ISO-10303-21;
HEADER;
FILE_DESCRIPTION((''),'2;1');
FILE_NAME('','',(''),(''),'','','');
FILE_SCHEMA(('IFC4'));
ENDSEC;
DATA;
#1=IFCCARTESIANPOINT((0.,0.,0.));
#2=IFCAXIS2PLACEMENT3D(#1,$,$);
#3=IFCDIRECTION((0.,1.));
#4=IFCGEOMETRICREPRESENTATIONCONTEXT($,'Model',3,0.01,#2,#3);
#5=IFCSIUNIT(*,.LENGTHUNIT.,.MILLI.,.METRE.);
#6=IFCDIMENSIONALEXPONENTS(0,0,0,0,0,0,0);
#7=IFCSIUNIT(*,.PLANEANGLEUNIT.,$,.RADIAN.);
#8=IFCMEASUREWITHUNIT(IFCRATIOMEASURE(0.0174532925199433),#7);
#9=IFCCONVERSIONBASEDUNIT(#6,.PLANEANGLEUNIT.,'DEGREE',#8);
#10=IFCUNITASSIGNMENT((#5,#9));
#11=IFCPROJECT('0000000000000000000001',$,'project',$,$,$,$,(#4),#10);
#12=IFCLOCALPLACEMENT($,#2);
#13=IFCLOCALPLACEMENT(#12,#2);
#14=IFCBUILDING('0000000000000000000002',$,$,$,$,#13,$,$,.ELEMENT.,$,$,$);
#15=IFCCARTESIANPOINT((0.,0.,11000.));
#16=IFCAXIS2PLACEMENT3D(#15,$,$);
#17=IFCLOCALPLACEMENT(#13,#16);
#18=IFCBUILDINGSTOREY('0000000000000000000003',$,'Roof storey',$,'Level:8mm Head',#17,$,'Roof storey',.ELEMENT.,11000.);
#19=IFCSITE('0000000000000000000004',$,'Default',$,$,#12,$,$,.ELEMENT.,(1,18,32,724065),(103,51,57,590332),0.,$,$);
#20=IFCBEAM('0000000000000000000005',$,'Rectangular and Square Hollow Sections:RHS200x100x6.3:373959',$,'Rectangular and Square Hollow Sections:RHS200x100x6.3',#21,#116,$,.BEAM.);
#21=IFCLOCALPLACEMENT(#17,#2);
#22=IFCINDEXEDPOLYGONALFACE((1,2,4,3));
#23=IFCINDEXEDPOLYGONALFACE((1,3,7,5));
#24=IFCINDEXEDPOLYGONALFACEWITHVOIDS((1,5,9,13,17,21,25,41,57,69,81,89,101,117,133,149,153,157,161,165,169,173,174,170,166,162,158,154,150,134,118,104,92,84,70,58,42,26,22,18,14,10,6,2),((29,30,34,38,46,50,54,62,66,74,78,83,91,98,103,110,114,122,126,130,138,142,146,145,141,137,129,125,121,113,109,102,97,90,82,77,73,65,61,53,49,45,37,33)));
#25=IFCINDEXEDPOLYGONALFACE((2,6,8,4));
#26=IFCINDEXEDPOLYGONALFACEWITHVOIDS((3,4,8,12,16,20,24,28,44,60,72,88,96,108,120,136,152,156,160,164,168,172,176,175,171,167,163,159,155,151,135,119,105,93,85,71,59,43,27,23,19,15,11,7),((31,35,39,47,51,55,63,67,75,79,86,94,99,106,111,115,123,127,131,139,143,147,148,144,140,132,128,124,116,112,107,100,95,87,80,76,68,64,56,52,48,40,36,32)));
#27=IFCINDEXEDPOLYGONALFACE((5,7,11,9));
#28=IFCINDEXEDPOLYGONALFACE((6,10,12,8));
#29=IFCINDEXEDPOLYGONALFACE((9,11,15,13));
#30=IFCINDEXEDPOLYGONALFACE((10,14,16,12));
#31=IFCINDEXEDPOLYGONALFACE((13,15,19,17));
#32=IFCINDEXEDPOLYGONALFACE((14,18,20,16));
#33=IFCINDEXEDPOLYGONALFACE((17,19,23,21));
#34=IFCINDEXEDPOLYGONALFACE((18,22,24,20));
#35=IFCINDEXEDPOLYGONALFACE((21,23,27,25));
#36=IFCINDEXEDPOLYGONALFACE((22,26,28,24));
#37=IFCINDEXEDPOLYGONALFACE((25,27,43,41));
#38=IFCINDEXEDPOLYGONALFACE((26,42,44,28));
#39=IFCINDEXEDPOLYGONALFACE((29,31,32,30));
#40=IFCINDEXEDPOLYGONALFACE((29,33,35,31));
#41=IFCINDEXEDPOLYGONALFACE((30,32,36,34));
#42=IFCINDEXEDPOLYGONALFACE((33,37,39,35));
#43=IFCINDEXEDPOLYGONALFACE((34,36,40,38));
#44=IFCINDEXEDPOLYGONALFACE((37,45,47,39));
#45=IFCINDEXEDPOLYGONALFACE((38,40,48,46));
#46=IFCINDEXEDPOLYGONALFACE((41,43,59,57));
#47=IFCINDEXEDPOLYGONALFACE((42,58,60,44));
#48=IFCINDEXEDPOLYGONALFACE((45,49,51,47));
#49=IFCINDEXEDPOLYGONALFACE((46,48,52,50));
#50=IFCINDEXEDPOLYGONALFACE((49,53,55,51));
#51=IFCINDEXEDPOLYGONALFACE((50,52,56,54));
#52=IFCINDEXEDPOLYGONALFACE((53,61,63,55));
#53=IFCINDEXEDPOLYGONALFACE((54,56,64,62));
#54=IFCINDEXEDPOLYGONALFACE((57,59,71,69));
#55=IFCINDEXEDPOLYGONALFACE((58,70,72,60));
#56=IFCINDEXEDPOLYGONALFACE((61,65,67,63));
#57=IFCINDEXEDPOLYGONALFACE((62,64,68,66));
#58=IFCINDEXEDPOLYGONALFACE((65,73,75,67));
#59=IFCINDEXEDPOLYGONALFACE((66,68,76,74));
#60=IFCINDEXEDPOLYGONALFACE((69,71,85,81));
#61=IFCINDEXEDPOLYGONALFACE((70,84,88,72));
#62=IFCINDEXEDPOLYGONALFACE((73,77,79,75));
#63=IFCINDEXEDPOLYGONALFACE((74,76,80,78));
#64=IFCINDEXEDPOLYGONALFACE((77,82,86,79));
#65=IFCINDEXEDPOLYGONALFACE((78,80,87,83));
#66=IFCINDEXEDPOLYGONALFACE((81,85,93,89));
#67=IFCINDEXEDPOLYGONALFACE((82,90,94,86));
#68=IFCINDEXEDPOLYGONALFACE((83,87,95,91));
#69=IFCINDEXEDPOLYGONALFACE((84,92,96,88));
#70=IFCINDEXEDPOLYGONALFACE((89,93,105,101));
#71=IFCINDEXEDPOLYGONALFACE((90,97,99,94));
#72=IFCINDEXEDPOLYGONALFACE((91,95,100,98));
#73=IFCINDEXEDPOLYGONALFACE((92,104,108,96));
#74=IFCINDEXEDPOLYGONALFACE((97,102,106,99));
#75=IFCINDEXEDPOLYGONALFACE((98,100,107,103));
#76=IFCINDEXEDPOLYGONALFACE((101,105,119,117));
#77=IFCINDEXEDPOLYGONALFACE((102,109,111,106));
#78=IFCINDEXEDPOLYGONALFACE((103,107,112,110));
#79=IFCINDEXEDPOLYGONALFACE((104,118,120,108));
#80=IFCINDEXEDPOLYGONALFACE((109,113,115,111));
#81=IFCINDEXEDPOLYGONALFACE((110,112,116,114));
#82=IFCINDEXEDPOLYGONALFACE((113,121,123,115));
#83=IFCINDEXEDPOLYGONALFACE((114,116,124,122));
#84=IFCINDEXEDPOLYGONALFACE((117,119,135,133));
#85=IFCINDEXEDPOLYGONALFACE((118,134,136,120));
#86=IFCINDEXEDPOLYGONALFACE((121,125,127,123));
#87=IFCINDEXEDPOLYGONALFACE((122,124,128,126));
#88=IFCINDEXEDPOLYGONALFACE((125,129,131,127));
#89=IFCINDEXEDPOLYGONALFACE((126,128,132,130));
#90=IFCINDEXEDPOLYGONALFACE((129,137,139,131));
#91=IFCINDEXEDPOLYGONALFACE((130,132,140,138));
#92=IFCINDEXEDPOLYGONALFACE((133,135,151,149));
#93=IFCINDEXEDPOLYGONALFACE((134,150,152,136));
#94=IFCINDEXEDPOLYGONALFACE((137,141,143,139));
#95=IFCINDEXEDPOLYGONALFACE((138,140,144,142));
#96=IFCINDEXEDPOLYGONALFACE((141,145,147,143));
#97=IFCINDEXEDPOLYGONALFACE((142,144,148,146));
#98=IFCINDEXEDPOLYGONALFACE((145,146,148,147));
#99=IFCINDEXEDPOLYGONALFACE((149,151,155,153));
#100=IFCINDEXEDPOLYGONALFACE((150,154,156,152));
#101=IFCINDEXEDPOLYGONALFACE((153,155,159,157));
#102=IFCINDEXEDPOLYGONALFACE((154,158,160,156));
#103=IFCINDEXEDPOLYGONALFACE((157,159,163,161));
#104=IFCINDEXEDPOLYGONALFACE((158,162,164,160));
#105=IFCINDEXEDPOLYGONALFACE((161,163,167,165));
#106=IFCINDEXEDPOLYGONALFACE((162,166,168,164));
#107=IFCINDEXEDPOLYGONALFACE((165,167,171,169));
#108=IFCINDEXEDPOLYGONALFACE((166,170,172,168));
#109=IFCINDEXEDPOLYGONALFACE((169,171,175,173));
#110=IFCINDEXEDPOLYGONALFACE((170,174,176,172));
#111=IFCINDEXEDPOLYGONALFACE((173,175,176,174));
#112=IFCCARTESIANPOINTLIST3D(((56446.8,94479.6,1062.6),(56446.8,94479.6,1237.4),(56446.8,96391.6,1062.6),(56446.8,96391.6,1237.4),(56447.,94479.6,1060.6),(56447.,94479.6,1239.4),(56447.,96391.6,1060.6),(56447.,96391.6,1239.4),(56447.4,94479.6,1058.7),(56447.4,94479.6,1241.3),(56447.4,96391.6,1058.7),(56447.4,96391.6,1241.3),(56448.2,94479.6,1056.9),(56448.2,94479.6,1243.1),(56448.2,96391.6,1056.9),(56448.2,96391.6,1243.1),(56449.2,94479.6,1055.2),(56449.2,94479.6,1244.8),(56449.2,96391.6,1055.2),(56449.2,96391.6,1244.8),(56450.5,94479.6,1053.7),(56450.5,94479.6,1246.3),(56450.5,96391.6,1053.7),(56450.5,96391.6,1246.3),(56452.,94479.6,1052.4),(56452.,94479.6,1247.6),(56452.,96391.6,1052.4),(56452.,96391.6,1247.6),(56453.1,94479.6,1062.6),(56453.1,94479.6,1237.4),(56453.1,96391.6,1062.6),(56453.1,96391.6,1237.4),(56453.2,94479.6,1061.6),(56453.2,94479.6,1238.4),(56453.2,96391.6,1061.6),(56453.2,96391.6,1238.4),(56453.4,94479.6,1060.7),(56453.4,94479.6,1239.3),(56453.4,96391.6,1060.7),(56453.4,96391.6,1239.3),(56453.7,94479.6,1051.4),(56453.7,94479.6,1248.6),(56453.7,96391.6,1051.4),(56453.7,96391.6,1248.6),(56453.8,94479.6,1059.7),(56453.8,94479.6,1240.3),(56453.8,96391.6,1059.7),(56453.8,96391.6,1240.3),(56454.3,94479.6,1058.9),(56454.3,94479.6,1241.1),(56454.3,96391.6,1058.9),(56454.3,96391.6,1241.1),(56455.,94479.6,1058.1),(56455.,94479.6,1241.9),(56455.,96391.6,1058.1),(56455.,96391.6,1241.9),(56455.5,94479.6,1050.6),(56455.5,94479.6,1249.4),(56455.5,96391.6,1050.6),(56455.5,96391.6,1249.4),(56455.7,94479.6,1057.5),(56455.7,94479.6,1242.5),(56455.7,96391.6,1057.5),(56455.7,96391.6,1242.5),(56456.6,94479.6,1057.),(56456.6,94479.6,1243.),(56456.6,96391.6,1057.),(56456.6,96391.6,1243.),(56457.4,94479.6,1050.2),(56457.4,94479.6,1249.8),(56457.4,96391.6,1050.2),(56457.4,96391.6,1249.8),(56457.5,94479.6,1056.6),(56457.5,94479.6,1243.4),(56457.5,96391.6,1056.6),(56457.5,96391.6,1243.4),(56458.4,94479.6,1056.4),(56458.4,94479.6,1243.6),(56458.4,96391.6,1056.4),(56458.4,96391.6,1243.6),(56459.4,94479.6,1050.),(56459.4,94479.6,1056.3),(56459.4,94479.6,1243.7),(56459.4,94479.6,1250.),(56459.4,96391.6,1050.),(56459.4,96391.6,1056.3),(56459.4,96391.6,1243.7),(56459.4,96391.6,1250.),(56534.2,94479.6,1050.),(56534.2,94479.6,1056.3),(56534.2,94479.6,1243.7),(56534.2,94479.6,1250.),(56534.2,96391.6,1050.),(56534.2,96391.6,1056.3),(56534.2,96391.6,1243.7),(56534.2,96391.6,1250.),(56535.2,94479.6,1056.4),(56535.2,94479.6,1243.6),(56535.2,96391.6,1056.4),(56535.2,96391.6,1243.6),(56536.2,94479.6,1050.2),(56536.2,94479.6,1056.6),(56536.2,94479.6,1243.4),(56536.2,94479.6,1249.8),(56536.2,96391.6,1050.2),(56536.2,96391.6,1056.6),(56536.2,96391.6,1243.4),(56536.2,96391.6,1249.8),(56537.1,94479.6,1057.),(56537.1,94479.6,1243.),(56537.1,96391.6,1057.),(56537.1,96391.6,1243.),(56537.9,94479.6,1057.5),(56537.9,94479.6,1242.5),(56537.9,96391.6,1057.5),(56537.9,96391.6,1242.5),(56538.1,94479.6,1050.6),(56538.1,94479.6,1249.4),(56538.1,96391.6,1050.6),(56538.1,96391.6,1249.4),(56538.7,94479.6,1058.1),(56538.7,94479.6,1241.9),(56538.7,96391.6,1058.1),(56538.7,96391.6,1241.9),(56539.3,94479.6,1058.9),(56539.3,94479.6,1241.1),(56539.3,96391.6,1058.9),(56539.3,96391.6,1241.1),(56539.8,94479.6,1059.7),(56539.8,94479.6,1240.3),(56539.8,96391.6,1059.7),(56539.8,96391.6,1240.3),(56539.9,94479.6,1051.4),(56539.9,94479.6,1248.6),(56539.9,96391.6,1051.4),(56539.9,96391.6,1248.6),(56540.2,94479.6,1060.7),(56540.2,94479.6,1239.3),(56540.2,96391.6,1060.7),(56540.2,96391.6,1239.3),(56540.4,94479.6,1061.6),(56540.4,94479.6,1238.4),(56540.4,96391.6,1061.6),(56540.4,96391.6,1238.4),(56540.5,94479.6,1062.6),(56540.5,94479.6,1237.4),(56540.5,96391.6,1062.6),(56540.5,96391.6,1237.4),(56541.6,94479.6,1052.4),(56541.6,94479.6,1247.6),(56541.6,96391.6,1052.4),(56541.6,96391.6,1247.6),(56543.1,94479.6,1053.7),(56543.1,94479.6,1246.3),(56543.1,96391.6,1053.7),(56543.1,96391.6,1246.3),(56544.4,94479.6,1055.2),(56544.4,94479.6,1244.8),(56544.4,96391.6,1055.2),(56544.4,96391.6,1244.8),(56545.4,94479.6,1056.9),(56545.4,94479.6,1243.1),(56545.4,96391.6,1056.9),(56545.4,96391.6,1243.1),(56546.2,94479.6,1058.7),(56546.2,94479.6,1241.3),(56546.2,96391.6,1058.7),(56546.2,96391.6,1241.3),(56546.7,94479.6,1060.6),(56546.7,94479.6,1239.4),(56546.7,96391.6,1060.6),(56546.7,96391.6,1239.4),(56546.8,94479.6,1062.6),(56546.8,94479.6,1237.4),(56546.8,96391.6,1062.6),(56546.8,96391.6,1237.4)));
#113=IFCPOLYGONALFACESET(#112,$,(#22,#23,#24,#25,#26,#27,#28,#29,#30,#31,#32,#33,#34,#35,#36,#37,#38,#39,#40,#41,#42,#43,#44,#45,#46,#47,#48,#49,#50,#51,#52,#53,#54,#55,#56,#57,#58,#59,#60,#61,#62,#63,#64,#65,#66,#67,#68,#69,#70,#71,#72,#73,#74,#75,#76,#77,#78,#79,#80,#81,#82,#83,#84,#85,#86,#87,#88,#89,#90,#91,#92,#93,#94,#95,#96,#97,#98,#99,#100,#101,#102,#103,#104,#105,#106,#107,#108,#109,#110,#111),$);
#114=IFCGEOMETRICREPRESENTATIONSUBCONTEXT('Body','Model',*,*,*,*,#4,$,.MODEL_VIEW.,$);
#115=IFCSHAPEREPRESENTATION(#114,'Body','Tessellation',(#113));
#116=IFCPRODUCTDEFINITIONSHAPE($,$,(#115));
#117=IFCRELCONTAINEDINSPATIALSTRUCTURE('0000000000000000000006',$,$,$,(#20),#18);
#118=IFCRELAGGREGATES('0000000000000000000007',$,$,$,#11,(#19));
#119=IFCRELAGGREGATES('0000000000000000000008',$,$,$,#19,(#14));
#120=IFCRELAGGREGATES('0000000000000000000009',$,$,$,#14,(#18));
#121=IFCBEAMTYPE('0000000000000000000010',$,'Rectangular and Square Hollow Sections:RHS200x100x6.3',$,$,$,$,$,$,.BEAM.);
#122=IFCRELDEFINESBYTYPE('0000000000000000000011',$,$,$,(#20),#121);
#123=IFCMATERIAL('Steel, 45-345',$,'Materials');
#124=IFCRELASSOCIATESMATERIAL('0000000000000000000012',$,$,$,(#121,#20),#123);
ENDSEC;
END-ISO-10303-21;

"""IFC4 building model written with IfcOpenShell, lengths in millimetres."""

from ifc_helpers import new_model, entity, si_unit, converted_unit, direction, frame, origin, place, context, subcontext, project, spatial, indexed_curve, outline, extrude, source, transform, mapped, material, type_object, type_shapes, element, save


model = new_model("IFC4")

# Units and contexts
model_context = context("Model", 3, precision=0.01, world=origin(), true_north=direction((0.0, 1.0)))
body_context = subcontext(model_context, "Body", "Model", "MODEL_VIEW")
ifc_project = project(units=[si_unit("LENGTHUNIT", "METRE", prefix="MILLI"), converted_unit("PLANEANGLEUNIT", "DEGREE", entity("IfcRatioMeasure", 0.0174532925199433), si_unit("PLANEANGLEUNIT", "RADIAN"), dimensions=[0, 0, 0, 0, 0, 0, 0])], contexts=[model_context])

# Site, building, storey
site_placement = place(None, origin())
site = spatial("IfcSite", under=ifc_project, at=site_placement, Name="Default", CompositionType="ELEMENT", RefLatitude=(1, 18, 32, 724065), RefLongitude=(103, 51, 57, 590332), RefElevation=0.0)
building_placement = place(site_placement, origin())
building = spatial("IfcBuilding", under=site, at=building_placement, CompositionType="ELEMENT")
storey_placement = place(building_placement, frame((0.0, 0.0, 11000.0)))
storey = spatial("IfcBuildingStorey", under=building, at=storey_placement, Name="Roof storey", ObjectType="Level:8mm Head", LongName="Roof storey", CompositionType="ELEMENT", Elevation=11000.0)

# Shared definitions
ifc_material = material(Name="Steel, 45-345", Category="Materials")

# Beam
beam_type_1 = type_object("IfcBeamType", Name="Rectangular and Square Hollow Sections:RHS200x100x6.3", PredefinedType="BEAM", material=ifc_material)
shared_shape_1 = source(origin(), body_context, "Body", "SweptSolid", [
    extrude(outline(indexed_curve([(-50.0, -87.4), (-49.8, -89.4), (-49.4, -91.3), (-48.6, -93.1), (-47.6, -94.8), (-46.3, -96.3), (-44.8, -97.6), (-43.1, -98.6), (-41.3, -99.4), (-39.4, -99.8), (-37.4, -100.0), (37.4, -100.0), (39.4, -99.8), (41.3, -99.4), (43.1, -98.6), (44.8, -97.6), (46.3, -96.3), (47.6, -94.8), (48.6, -93.1), (49.4, -91.3), (49.8, -89.4), (50.0, -87.4), (50.0, 87.4), (49.8, 89.4), (49.4, 91.3), (48.6, 93.1), (47.6, 94.8), (46.3, 96.3), (44.8, 97.6), (43.1, 98.6), (41.3, 99.4), (39.4, 99.8), (37.4, 100.0), (-37.4, 100.0), (-39.4, 99.8), (-41.3, 99.4), (-43.1, 98.6), (-44.8, 97.6), (-46.3, 96.3), (-47.6, 94.8), (-48.6, 93.1), (-49.4, 91.3), (-49.8, 89.4), (-50.0, 87.4), (-50.0, -87.4)], self_intersect=False), holes=[indexed_curve([(37.4, -93.7), (-37.4, -93.7), (-38.4, -93.6), (-39.3, -93.4), (-40.3, -93.0), (-41.1, -92.5), (-41.9, -91.9), (-42.5, -91.1), (-43.0, -90.3), (-43.4, -89.3), (-43.6, -88.4), (-43.7, -87.4), (-43.7, 87.4), (-43.6, 88.4), (-43.4, 89.3), (-43.0, 90.3), (-42.5, 91.1), (-41.9, 91.9), (-41.1, 92.5), (-40.3, 93.0), (-39.3, 93.4), (-38.4, 93.6), (-37.4, 93.7), (37.4, 93.7), (38.4, 93.6), (39.3, 93.4), (40.3, 93.0), (41.1, 92.5), (41.9, 91.9), (42.5, 91.1), (43.0, 90.3), (43.4, 89.3), (43.6, 88.4), (43.7, 87.4), (43.7, -87.4), (43.6, -88.4), (43.4, -89.3), (43.0, -90.3), (42.5, -91.1), (41.9, -91.9), (41.1, -92.5), (40.3, -93.0), (39.3, -93.4), (38.4, -93.6), (37.4, -93.7)], self_intersect=False)]), frame((-977.5, 0.0, 0.0), z_axis=(1.0, 0.0, 0.0), x_axis=(0.0, -1.0, 0.0)), (0.0, 0.0, 1.0), 1912.0),
])
type_shapes(beam_type_1, [shared_shape_1])
beam_1_placement = place(storey_placement, frame((56496.8, 95457.1, 1150.0), z_axis=(0.0, 0.0, 1.0), x_axis=(0.0, 1.0, 0.0)))
element("IfcBeam", 1, at=beam_1_placement, inside=storey, type_object=beam_type_1, material=ifc_material, Name="Rectangular and Square Hollow Sections:RHS200x100x6.3:373959", ObjectType="Rectangular and Square Hollow Sections:RHS200x100x6.3", PredefinedType="BEAM", context=body_context, shape_type="MappedRepresentation", body=[
    mapped(shared_shape_1, transform((0.0, 0.0, 0.0), scale=1.0)),
])

save(model, "model.ifc")
